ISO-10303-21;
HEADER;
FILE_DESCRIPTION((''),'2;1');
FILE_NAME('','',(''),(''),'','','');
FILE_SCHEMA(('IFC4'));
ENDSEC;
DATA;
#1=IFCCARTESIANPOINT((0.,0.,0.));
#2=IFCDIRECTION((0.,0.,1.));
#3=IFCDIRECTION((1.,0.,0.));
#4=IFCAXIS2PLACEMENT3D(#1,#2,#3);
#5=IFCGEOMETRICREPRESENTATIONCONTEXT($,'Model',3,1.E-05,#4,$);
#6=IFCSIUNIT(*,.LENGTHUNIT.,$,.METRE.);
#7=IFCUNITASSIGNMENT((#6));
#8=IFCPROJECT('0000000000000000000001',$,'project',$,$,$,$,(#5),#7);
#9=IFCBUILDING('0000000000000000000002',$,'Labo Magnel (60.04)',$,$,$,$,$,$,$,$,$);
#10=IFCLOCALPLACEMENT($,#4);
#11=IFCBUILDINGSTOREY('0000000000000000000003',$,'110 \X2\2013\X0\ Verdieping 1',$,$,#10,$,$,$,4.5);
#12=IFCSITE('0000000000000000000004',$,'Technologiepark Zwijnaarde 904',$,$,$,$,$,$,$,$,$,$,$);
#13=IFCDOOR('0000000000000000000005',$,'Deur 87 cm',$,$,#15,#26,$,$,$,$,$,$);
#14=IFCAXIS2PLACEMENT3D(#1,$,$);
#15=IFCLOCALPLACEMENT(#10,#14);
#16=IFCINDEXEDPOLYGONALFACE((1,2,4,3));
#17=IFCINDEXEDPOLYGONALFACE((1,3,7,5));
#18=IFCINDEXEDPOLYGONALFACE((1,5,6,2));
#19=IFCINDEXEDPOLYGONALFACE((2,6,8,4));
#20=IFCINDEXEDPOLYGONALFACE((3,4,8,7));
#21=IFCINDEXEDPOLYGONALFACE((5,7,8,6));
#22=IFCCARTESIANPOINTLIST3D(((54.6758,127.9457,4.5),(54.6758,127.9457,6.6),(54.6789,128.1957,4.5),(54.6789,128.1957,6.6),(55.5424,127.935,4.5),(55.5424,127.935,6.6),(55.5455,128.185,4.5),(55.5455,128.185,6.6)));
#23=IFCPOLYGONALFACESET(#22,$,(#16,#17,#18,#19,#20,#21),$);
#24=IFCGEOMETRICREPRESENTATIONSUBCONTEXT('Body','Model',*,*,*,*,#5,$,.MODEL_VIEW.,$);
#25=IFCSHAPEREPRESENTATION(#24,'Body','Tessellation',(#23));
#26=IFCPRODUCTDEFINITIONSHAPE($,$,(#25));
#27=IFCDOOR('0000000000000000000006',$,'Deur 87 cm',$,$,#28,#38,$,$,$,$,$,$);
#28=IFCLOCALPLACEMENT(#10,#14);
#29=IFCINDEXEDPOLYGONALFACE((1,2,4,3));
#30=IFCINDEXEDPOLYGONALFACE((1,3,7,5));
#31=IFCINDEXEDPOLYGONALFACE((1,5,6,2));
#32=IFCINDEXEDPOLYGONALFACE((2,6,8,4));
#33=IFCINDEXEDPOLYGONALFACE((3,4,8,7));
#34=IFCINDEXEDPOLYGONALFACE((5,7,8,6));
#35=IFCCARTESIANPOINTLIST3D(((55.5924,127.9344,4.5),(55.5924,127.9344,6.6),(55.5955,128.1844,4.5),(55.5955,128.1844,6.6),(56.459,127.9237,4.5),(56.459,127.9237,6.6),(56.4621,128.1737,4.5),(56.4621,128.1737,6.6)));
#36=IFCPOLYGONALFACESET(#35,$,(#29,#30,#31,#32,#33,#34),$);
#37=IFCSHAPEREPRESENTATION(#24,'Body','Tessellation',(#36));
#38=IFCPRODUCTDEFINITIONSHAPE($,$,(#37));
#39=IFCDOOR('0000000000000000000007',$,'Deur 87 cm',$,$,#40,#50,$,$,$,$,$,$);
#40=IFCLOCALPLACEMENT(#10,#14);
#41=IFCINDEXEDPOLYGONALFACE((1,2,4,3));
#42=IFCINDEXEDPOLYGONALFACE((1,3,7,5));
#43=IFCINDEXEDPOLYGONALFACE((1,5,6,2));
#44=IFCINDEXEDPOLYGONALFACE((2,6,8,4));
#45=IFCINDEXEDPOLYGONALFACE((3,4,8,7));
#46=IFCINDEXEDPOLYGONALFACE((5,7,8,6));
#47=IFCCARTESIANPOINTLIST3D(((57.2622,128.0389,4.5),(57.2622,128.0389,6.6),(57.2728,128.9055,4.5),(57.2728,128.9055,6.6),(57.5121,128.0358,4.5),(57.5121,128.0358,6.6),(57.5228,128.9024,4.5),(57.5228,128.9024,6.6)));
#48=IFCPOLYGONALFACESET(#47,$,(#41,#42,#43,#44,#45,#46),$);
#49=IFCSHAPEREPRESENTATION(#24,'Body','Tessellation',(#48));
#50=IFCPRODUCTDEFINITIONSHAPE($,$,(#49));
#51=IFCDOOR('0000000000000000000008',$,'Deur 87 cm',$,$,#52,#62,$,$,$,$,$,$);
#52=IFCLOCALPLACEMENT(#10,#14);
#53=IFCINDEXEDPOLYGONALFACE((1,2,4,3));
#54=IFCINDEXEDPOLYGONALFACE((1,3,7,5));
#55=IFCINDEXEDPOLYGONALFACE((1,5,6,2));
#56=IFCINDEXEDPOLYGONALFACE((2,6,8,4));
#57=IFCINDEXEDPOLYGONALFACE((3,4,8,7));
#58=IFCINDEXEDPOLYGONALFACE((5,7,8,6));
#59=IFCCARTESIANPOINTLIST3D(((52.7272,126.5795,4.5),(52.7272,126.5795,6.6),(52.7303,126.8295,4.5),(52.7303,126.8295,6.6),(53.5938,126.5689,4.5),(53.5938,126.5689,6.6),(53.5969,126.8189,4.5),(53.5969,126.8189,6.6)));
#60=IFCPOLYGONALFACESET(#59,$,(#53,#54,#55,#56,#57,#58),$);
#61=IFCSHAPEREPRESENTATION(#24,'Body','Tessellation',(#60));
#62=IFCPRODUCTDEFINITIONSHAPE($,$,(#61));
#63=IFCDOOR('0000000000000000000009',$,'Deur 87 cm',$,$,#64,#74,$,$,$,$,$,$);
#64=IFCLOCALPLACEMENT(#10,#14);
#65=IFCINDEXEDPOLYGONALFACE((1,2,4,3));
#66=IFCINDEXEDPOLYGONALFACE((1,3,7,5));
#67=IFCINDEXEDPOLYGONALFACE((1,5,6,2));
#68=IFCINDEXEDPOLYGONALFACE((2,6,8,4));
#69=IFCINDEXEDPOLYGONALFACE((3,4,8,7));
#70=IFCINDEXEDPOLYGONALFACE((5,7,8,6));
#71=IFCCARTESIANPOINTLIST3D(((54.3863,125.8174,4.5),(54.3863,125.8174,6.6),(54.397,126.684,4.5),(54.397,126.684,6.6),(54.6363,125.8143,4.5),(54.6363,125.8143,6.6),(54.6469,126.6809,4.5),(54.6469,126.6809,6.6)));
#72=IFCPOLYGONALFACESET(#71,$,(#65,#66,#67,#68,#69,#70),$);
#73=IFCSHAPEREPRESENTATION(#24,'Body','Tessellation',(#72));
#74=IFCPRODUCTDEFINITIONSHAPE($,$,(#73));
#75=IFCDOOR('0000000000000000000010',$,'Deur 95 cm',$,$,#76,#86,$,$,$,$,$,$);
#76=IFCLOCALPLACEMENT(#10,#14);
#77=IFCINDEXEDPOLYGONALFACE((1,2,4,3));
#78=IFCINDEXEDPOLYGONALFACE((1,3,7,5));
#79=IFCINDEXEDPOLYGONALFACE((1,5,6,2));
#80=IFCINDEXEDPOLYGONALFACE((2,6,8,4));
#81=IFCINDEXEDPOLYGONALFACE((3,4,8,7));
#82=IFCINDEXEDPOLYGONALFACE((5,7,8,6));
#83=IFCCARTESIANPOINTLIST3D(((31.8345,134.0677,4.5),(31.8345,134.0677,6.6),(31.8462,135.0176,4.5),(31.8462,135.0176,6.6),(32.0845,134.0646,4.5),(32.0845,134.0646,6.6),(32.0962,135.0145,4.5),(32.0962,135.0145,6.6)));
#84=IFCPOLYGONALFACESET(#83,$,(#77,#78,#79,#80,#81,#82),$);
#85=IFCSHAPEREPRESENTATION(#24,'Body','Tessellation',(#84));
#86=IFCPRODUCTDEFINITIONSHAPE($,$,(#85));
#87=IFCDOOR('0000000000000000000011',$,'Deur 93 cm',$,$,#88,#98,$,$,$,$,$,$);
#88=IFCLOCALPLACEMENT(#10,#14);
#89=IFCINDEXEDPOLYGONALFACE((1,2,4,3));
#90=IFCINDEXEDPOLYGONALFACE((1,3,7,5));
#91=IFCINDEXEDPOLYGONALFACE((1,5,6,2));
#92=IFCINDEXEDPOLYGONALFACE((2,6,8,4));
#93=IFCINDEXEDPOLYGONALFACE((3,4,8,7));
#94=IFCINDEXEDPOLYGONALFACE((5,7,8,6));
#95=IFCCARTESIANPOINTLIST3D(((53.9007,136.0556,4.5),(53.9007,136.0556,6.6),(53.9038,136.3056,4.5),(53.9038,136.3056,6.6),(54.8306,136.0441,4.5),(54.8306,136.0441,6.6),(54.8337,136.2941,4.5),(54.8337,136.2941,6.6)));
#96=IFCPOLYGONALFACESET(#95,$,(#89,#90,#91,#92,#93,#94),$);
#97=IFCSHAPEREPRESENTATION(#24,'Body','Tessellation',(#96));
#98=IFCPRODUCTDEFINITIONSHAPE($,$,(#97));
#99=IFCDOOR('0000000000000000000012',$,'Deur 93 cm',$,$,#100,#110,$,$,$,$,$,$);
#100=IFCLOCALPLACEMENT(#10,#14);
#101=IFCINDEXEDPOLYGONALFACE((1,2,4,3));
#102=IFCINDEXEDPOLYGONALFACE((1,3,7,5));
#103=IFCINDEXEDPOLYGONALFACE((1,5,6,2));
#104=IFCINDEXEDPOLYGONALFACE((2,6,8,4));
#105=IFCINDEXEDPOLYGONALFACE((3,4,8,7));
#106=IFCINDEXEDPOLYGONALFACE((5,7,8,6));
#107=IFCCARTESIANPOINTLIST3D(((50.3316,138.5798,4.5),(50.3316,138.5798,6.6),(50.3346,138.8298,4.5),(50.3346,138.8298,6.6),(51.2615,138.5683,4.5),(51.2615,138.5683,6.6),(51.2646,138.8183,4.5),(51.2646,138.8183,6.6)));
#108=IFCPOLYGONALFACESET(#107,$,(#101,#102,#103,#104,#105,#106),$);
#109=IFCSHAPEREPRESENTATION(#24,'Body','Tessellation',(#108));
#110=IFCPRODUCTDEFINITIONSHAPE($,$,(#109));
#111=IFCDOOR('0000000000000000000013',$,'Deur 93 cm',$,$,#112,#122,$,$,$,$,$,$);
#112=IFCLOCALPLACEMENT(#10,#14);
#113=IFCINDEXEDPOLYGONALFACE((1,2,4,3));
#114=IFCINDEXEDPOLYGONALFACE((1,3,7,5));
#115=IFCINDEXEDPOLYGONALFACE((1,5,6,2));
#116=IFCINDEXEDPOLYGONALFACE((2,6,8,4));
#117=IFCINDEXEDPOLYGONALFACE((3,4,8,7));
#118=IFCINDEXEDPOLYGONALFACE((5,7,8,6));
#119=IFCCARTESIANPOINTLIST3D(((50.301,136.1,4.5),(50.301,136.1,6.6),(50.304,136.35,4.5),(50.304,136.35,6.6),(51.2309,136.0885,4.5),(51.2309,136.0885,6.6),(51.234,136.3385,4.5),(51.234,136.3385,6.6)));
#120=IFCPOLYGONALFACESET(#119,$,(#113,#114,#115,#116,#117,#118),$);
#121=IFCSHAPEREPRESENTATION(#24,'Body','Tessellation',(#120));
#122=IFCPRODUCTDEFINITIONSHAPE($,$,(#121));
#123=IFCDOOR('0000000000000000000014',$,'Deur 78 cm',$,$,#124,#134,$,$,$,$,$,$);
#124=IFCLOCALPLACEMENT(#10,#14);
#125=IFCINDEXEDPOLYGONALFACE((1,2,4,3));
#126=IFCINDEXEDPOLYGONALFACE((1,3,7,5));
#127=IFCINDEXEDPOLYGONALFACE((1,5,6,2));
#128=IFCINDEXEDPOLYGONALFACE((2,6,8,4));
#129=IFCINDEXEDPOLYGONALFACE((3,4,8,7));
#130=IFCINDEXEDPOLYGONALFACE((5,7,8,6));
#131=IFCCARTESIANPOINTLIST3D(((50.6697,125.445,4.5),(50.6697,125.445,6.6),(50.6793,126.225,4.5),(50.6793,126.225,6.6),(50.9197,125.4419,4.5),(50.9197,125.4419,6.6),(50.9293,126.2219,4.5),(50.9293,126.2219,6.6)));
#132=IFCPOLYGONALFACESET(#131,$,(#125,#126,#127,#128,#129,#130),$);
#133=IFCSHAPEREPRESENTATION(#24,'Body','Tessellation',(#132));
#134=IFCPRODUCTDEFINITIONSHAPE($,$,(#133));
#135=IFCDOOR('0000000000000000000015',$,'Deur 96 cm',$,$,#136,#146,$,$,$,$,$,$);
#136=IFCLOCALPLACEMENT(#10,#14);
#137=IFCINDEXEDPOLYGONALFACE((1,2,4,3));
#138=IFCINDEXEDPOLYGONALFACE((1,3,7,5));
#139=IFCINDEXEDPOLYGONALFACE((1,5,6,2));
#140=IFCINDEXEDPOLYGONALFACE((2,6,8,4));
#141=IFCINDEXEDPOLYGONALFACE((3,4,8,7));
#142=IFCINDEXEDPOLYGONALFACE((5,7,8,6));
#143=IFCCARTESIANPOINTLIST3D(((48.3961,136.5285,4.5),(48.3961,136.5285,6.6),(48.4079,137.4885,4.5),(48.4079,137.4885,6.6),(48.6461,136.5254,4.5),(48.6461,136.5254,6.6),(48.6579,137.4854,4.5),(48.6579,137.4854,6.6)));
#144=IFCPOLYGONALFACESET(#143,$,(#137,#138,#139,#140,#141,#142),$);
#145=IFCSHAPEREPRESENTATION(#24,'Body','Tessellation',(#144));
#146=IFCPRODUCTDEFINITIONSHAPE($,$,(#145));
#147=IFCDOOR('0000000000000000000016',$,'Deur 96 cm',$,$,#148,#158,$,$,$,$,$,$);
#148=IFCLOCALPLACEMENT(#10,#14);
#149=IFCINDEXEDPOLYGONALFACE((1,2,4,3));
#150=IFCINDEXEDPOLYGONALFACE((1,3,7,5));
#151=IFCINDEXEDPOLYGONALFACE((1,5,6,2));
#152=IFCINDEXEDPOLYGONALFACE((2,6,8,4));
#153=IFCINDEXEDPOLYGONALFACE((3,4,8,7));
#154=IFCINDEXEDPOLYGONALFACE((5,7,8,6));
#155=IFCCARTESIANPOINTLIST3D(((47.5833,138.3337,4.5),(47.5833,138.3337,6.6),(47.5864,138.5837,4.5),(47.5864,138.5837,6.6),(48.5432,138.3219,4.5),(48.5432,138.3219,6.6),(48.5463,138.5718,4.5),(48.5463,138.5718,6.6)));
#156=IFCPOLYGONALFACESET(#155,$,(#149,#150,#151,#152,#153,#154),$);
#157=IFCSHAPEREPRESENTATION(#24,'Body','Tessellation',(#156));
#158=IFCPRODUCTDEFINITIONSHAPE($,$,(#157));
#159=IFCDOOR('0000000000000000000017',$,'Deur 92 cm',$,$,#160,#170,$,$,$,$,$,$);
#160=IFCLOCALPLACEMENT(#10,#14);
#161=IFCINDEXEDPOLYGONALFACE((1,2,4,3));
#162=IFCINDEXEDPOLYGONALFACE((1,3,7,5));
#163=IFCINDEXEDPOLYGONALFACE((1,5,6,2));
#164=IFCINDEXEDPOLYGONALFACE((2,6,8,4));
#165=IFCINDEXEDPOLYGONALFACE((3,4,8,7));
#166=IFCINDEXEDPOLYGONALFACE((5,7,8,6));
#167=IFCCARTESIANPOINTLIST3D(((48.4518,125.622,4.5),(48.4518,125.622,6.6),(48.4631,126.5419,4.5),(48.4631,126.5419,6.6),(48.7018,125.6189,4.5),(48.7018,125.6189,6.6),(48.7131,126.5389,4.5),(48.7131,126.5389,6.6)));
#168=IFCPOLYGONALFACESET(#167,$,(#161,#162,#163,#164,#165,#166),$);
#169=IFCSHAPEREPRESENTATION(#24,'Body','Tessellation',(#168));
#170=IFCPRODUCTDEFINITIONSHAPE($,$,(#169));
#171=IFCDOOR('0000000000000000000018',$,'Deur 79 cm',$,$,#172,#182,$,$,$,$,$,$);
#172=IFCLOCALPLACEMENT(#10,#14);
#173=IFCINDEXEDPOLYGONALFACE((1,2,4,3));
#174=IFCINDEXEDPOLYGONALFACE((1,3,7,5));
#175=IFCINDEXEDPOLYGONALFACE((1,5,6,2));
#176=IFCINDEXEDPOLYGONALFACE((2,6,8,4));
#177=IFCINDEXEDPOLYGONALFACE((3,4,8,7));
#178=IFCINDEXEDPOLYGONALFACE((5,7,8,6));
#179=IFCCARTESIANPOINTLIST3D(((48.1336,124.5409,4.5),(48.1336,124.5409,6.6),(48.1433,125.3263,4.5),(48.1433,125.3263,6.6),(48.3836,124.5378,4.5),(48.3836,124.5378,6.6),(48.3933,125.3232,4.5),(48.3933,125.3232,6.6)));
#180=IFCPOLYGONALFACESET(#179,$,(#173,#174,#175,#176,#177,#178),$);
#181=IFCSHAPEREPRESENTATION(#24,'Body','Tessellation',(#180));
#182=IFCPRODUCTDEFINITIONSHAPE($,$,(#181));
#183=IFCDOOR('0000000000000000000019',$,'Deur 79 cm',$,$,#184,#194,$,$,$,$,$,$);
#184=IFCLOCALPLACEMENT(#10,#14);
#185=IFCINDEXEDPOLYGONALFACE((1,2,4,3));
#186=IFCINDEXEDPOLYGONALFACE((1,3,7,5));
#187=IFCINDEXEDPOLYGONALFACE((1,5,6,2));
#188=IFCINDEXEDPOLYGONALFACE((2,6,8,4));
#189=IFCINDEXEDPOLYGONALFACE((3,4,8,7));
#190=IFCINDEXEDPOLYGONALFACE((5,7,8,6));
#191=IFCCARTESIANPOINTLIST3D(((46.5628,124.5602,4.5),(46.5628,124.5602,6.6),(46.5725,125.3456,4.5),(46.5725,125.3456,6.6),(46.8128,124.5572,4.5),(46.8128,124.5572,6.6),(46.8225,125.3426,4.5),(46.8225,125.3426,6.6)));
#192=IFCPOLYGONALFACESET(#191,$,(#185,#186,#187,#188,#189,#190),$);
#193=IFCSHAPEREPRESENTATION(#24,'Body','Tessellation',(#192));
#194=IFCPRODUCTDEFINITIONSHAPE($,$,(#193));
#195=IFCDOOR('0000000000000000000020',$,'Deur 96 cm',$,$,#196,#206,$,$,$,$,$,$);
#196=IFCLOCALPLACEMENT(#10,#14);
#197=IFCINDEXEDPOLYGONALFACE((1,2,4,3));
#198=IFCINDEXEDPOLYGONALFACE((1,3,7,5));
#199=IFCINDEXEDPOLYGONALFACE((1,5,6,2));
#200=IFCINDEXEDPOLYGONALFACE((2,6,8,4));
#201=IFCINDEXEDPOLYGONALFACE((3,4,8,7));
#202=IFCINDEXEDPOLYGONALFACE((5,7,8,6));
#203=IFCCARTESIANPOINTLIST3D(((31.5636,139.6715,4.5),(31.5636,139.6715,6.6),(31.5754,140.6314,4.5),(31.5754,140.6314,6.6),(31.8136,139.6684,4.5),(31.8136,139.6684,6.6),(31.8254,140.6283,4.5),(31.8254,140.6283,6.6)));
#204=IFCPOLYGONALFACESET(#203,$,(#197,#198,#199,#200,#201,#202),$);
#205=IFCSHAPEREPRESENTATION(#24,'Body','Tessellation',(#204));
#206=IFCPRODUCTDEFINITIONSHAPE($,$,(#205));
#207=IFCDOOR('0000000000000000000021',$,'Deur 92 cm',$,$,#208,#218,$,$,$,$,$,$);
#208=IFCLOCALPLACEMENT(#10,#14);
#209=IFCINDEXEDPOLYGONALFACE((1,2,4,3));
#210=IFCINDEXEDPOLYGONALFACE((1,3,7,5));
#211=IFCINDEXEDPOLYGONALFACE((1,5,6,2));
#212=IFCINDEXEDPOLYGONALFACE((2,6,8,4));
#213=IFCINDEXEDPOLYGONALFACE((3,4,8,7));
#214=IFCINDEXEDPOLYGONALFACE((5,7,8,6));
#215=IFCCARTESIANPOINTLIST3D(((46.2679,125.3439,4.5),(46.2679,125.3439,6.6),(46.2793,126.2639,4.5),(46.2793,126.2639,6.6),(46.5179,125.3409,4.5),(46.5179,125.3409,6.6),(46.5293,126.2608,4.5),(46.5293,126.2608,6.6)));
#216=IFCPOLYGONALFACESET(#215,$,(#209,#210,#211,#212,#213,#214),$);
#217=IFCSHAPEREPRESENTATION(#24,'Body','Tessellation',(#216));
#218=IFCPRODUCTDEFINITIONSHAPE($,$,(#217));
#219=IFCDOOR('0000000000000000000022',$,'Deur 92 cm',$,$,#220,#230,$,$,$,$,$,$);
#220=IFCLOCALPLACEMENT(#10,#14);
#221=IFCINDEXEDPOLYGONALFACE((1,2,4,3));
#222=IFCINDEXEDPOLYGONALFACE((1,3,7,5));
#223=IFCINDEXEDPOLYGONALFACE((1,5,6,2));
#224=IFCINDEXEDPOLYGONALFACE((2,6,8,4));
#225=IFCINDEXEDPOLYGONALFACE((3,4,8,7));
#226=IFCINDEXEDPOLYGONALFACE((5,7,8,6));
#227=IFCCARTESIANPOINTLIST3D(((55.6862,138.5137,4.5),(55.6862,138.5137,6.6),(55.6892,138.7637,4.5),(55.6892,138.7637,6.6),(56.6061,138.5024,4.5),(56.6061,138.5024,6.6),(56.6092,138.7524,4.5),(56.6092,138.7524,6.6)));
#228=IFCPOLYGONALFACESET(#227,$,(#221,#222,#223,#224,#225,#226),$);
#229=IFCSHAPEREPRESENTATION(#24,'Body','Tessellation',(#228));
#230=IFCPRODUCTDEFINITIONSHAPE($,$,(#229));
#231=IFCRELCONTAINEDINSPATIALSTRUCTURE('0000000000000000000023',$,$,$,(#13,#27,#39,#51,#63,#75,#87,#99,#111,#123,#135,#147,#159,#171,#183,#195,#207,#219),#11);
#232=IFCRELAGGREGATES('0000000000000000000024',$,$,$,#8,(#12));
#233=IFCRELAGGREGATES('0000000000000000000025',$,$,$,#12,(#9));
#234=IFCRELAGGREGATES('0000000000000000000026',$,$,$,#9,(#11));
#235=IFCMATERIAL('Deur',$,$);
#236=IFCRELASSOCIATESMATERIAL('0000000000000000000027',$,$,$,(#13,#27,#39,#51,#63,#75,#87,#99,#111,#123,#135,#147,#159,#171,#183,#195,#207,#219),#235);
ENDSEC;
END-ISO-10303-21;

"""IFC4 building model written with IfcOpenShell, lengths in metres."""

from ifc_helpers import new_model, si_unit, frame, origin, origin_with_axes, place, context, subcontext, project, spatial, polyline, outline, extrude, material, element, save


model = new_model("IFC4")

# Units and contexts
model_context = context("Model", 3, precision=1e-05, world=origin_with_axes())
body_context = subcontext(model_context, "Body", "Model", "MODEL_VIEW")
ifc_project = project(units=[si_unit("LENGTHUNIT", "METRE")], contexts=[model_context])

# Site, building, storey
site = spatial("IfcSite", under=ifc_project, Name="Technologiepark Zwijnaarde 904")
building = spatial("IfcBuilding", under=site, Name="Labo Magnel (60.04)")
storey_placement = place(None, origin_with_axes())
storey = spatial("IfcBuildingStorey", under=building, at=storey_placement, Name="110 – Verdieping 1", Elevation=4.5)

# Doors
ifc_material_1 = material(Name="Deur")
for number, where, z_axis, x_axis, name in (
    (1, (55.544, 128.06, 4.5), (0.0, 0.0, 1.0), (-0.999924, 0.012293, 0.0), "Deur 87 cm"),
    (2, (56.4606, 128.0487, 4.5), (0.0, 0.0, 1.0), (-0.999924, 0.012293, 0.0), "Deur 87 cm"),
    (3, (57.3872, 128.0373, 4.5), (0.0, 0.0, 1.0), (0.012293, 0.999924, 0.0), "Deur 87 cm"),
    (4, (53.5954, 126.6939, 4.5), (0.0, 0.0, 1.0), (-0.999924, 0.012293, 0.0), "Deur 87 cm"),
    (5, (54.5219, 126.6825, 4.5), (0.0, 0.0, 1.0), (-0.012293, -0.999924, 0.0), "Deur 87 cm"),
):
    element("IfcDoor", number, at=place(storey_placement, frame(where, z_axis=z_axis, x_axis=x_axis)), inside=storey, material=ifc_material_1, Name=name, context=body_context, shape_type="SweptSolid", body=[
        extrude(outline(polyline([(0.0, -0.125), (0.8667, -0.125), (0.8667, 0.125), (0.0, 0.125), (0.0, -0.125)])), origin(), (0.0, 0.0, 1.0), 2.1),
    ])
door_1_placement = place(storey_placement, frame((31.9595, 134.0661, 4.5), z_axis=(0.0, 0.0, 1.0), x_axis=(0.012338, 0.999924, 0.0)))
element("IfcDoor", 6, at=door_1_placement, inside=storey, material=ifc_material_1, Name="Deur 95 cm", context=body_context, shape_type="SweptSolid", body=[
    extrude(outline(polyline([(0.0, -0.125), (0.95, -0.125), (0.95, 0.125), (0.0, 0.125), (0.0, -0.125)])), origin(), (0.0, 0.0, 1.0), 2.1),
])
for number, where, z_axis, x_axis, name in (
    (7, (53.9022, 136.1806, 4.5), (0.0, 0.0, 1.0), (0.999924, -0.012338, 0.0), "Deur 93 cm"),
    (8, (50.3331, 138.7048, 4.5), (0.0, 0.0, 1.0), (0.999924, -0.012338, 0.0), "Deur 93 cm"),
    (9, (50.3025, 136.225, 4.5), (0.0, 0.0, 1.0), (0.999924, -0.012338, 0.0), "Deur 93 cm"),
):
    element("IfcDoor", number, at=place(storey_placement, frame(where, z_axis=z_axis, x_axis=x_axis)), inside=storey, material=ifc_material_1, Name=name, context=body_context, shape_type="SweptSolid", body=[
        extrude(outline(polyline([(0.0, -0.125), (0.93, -0.125), (0.93, 0.125), (0.0, 0.125), (0.0, -0.125)])), origin(), (0.0, 0.0, 1.0), 2.1),
    ])
door_2_placement = place(storey_placement, frame((50.7947, 125.4435, 4.5), z_axis=(0.0, 0.0, 1.0), x_axis=(0.012338, 0.999924, 0.0)))
element("IfcDoor", 10, at=door_2_placement, inside=storey, material=ifc_material_1, Name="Deur 78 cm", context=body_context, shape_type="SweptSolid", body=[
    extrude(outline(polyline([(0.0, -0.125), (0.78, -0.125), (0.78, 0.125), (0.0, 0.125), (0.0, -0.125)])), origin(), (0.0, 0.0, 1.0), 2.1),
])
for number, where, z_axis, x_axis, name in (
    (11, (48.5211, 136.527, 4.5), (0.0, 0.0, 1.0), (0.012338, 0.999924, 0.0), "Deur 96 cm"),
    (12, (48.5448, 138.4468, 4.5), (0.0, 0.0, 1.0), (-0.999924, 0.012338, 0.0), "Deur 96 cm"),
):
    element("IfcDoor", number, at=place(storey_placement, frame(where, z_axis=z_axis, x_axis=x_axis)), inside=storey, material=ifc_material_1, Name=name, context=body_context, shape_type="SweptSolid", body=[
        extrude(outline(polyline([(0.0, -0.125), (0.96, -0.125), (0.96, 0.125), (0.0, 0.125), (0.0, -0.125)])), origin(), (0.0, 0.0, 1.0), 2.1),
    ])
door_3_placement = place(storey_placement, frame((48.5881, 126.5404, 4.5), z_axis=(0.0, 0.0, 1.0), x_axis=(-0.012293, -0.999924, 0.0)))
element("IfcDoor", 13, at=door_3_placement, inside=storey, material=ifc_material_1, Name="Deur 92 cm", context=body_context, shape_type="SweptSolid", body=[
    extrude(outline(polyline([(0.0, -0.125), (0.92, -0.125), (0.92, 0.125), (0.0, 0.125), (0.0, -0.125)])), origin(), (0.0, 0.0, 1.0), 2.1),
])
for number, where, z_axis, x_axis, name in (
    (14, (48.2586, 124.5393, 4.5), (0.0, 0.0, 1.0), (0.012338, 0.999924, 0.0), "Deur 79 cm"),
    (15, (46.6878, 124.5587, 4.5), (0.0, 0.0, 1.0), (0.012338, 0.999924, 0.0), "Deur 79 cm"),
):
    element("IfcDoor", number, at=place(storey_placement, frame(where, z_axis=z_axis, x_axis=x_axis)), inside=storey, material=ifc_material_1, Name=name, context=body_context, shape_type="SweptSolid", body=[
        extrude(outline(polyline([(0.0, -0.125), (0.7855, -0.125), (0.7855, 0.125), (0.0, 0.125), (0.0, -0.125)])), origin(), (0.0, 0.0, 1.0), 2.1),
    ])
door_4_placement = place(storey_placement, frame((31.7004, 140.6298, 4.5), z_axis=(0.0, 0.0, 1.0), x_axis=(-0.012338, -0.999924, 0.0)))
element("IfcDoor", 16, at=door_4_placement, inside=storey, material=ifc_material_1, Name="Deur 96 cm", context=body_context, shape_type="SweptSolid", body=[
    extrude(outline(polyline([(0.0, -0.125), (0.96, -0.125), (0.96, 0.125), (0.0, 0.125), (0.0, -0.125)])), origin(), (0.0, 0.0, 1.0), 2.1),
])
for number, where, z_axis, x_axis, name in (
    (17, (46.3929, 125.3424, 4.5), (0.0, 0.0, 1.0), (0.012338, 0.999924, 0.0), "Deur 92 cm"),
    (18, (55.6877, 138.6387, 4.5), (0.0, 0.0, 1.0), (0.999924, -0.012338, 0.0), "Deur 92 cm"),
):
    element("IfcDoor", number, at=place(storey_placement, frame(where, z_axis=z_axis, x_axis=x_axis)), inside=storey, material=ifc_material_1, Name=name, context=body_context, shape_type="SweptSolid", body=[
        extrude(outline(polyline([(0.0, -0.125), (0.92, -0.125), (0.92, 0.125), (0.0, 0.125), (0.0, -0.125)])), origin(), (0.0, 0.0, 1.0), 2.1),
    ])

save(model, "model.ifc")
